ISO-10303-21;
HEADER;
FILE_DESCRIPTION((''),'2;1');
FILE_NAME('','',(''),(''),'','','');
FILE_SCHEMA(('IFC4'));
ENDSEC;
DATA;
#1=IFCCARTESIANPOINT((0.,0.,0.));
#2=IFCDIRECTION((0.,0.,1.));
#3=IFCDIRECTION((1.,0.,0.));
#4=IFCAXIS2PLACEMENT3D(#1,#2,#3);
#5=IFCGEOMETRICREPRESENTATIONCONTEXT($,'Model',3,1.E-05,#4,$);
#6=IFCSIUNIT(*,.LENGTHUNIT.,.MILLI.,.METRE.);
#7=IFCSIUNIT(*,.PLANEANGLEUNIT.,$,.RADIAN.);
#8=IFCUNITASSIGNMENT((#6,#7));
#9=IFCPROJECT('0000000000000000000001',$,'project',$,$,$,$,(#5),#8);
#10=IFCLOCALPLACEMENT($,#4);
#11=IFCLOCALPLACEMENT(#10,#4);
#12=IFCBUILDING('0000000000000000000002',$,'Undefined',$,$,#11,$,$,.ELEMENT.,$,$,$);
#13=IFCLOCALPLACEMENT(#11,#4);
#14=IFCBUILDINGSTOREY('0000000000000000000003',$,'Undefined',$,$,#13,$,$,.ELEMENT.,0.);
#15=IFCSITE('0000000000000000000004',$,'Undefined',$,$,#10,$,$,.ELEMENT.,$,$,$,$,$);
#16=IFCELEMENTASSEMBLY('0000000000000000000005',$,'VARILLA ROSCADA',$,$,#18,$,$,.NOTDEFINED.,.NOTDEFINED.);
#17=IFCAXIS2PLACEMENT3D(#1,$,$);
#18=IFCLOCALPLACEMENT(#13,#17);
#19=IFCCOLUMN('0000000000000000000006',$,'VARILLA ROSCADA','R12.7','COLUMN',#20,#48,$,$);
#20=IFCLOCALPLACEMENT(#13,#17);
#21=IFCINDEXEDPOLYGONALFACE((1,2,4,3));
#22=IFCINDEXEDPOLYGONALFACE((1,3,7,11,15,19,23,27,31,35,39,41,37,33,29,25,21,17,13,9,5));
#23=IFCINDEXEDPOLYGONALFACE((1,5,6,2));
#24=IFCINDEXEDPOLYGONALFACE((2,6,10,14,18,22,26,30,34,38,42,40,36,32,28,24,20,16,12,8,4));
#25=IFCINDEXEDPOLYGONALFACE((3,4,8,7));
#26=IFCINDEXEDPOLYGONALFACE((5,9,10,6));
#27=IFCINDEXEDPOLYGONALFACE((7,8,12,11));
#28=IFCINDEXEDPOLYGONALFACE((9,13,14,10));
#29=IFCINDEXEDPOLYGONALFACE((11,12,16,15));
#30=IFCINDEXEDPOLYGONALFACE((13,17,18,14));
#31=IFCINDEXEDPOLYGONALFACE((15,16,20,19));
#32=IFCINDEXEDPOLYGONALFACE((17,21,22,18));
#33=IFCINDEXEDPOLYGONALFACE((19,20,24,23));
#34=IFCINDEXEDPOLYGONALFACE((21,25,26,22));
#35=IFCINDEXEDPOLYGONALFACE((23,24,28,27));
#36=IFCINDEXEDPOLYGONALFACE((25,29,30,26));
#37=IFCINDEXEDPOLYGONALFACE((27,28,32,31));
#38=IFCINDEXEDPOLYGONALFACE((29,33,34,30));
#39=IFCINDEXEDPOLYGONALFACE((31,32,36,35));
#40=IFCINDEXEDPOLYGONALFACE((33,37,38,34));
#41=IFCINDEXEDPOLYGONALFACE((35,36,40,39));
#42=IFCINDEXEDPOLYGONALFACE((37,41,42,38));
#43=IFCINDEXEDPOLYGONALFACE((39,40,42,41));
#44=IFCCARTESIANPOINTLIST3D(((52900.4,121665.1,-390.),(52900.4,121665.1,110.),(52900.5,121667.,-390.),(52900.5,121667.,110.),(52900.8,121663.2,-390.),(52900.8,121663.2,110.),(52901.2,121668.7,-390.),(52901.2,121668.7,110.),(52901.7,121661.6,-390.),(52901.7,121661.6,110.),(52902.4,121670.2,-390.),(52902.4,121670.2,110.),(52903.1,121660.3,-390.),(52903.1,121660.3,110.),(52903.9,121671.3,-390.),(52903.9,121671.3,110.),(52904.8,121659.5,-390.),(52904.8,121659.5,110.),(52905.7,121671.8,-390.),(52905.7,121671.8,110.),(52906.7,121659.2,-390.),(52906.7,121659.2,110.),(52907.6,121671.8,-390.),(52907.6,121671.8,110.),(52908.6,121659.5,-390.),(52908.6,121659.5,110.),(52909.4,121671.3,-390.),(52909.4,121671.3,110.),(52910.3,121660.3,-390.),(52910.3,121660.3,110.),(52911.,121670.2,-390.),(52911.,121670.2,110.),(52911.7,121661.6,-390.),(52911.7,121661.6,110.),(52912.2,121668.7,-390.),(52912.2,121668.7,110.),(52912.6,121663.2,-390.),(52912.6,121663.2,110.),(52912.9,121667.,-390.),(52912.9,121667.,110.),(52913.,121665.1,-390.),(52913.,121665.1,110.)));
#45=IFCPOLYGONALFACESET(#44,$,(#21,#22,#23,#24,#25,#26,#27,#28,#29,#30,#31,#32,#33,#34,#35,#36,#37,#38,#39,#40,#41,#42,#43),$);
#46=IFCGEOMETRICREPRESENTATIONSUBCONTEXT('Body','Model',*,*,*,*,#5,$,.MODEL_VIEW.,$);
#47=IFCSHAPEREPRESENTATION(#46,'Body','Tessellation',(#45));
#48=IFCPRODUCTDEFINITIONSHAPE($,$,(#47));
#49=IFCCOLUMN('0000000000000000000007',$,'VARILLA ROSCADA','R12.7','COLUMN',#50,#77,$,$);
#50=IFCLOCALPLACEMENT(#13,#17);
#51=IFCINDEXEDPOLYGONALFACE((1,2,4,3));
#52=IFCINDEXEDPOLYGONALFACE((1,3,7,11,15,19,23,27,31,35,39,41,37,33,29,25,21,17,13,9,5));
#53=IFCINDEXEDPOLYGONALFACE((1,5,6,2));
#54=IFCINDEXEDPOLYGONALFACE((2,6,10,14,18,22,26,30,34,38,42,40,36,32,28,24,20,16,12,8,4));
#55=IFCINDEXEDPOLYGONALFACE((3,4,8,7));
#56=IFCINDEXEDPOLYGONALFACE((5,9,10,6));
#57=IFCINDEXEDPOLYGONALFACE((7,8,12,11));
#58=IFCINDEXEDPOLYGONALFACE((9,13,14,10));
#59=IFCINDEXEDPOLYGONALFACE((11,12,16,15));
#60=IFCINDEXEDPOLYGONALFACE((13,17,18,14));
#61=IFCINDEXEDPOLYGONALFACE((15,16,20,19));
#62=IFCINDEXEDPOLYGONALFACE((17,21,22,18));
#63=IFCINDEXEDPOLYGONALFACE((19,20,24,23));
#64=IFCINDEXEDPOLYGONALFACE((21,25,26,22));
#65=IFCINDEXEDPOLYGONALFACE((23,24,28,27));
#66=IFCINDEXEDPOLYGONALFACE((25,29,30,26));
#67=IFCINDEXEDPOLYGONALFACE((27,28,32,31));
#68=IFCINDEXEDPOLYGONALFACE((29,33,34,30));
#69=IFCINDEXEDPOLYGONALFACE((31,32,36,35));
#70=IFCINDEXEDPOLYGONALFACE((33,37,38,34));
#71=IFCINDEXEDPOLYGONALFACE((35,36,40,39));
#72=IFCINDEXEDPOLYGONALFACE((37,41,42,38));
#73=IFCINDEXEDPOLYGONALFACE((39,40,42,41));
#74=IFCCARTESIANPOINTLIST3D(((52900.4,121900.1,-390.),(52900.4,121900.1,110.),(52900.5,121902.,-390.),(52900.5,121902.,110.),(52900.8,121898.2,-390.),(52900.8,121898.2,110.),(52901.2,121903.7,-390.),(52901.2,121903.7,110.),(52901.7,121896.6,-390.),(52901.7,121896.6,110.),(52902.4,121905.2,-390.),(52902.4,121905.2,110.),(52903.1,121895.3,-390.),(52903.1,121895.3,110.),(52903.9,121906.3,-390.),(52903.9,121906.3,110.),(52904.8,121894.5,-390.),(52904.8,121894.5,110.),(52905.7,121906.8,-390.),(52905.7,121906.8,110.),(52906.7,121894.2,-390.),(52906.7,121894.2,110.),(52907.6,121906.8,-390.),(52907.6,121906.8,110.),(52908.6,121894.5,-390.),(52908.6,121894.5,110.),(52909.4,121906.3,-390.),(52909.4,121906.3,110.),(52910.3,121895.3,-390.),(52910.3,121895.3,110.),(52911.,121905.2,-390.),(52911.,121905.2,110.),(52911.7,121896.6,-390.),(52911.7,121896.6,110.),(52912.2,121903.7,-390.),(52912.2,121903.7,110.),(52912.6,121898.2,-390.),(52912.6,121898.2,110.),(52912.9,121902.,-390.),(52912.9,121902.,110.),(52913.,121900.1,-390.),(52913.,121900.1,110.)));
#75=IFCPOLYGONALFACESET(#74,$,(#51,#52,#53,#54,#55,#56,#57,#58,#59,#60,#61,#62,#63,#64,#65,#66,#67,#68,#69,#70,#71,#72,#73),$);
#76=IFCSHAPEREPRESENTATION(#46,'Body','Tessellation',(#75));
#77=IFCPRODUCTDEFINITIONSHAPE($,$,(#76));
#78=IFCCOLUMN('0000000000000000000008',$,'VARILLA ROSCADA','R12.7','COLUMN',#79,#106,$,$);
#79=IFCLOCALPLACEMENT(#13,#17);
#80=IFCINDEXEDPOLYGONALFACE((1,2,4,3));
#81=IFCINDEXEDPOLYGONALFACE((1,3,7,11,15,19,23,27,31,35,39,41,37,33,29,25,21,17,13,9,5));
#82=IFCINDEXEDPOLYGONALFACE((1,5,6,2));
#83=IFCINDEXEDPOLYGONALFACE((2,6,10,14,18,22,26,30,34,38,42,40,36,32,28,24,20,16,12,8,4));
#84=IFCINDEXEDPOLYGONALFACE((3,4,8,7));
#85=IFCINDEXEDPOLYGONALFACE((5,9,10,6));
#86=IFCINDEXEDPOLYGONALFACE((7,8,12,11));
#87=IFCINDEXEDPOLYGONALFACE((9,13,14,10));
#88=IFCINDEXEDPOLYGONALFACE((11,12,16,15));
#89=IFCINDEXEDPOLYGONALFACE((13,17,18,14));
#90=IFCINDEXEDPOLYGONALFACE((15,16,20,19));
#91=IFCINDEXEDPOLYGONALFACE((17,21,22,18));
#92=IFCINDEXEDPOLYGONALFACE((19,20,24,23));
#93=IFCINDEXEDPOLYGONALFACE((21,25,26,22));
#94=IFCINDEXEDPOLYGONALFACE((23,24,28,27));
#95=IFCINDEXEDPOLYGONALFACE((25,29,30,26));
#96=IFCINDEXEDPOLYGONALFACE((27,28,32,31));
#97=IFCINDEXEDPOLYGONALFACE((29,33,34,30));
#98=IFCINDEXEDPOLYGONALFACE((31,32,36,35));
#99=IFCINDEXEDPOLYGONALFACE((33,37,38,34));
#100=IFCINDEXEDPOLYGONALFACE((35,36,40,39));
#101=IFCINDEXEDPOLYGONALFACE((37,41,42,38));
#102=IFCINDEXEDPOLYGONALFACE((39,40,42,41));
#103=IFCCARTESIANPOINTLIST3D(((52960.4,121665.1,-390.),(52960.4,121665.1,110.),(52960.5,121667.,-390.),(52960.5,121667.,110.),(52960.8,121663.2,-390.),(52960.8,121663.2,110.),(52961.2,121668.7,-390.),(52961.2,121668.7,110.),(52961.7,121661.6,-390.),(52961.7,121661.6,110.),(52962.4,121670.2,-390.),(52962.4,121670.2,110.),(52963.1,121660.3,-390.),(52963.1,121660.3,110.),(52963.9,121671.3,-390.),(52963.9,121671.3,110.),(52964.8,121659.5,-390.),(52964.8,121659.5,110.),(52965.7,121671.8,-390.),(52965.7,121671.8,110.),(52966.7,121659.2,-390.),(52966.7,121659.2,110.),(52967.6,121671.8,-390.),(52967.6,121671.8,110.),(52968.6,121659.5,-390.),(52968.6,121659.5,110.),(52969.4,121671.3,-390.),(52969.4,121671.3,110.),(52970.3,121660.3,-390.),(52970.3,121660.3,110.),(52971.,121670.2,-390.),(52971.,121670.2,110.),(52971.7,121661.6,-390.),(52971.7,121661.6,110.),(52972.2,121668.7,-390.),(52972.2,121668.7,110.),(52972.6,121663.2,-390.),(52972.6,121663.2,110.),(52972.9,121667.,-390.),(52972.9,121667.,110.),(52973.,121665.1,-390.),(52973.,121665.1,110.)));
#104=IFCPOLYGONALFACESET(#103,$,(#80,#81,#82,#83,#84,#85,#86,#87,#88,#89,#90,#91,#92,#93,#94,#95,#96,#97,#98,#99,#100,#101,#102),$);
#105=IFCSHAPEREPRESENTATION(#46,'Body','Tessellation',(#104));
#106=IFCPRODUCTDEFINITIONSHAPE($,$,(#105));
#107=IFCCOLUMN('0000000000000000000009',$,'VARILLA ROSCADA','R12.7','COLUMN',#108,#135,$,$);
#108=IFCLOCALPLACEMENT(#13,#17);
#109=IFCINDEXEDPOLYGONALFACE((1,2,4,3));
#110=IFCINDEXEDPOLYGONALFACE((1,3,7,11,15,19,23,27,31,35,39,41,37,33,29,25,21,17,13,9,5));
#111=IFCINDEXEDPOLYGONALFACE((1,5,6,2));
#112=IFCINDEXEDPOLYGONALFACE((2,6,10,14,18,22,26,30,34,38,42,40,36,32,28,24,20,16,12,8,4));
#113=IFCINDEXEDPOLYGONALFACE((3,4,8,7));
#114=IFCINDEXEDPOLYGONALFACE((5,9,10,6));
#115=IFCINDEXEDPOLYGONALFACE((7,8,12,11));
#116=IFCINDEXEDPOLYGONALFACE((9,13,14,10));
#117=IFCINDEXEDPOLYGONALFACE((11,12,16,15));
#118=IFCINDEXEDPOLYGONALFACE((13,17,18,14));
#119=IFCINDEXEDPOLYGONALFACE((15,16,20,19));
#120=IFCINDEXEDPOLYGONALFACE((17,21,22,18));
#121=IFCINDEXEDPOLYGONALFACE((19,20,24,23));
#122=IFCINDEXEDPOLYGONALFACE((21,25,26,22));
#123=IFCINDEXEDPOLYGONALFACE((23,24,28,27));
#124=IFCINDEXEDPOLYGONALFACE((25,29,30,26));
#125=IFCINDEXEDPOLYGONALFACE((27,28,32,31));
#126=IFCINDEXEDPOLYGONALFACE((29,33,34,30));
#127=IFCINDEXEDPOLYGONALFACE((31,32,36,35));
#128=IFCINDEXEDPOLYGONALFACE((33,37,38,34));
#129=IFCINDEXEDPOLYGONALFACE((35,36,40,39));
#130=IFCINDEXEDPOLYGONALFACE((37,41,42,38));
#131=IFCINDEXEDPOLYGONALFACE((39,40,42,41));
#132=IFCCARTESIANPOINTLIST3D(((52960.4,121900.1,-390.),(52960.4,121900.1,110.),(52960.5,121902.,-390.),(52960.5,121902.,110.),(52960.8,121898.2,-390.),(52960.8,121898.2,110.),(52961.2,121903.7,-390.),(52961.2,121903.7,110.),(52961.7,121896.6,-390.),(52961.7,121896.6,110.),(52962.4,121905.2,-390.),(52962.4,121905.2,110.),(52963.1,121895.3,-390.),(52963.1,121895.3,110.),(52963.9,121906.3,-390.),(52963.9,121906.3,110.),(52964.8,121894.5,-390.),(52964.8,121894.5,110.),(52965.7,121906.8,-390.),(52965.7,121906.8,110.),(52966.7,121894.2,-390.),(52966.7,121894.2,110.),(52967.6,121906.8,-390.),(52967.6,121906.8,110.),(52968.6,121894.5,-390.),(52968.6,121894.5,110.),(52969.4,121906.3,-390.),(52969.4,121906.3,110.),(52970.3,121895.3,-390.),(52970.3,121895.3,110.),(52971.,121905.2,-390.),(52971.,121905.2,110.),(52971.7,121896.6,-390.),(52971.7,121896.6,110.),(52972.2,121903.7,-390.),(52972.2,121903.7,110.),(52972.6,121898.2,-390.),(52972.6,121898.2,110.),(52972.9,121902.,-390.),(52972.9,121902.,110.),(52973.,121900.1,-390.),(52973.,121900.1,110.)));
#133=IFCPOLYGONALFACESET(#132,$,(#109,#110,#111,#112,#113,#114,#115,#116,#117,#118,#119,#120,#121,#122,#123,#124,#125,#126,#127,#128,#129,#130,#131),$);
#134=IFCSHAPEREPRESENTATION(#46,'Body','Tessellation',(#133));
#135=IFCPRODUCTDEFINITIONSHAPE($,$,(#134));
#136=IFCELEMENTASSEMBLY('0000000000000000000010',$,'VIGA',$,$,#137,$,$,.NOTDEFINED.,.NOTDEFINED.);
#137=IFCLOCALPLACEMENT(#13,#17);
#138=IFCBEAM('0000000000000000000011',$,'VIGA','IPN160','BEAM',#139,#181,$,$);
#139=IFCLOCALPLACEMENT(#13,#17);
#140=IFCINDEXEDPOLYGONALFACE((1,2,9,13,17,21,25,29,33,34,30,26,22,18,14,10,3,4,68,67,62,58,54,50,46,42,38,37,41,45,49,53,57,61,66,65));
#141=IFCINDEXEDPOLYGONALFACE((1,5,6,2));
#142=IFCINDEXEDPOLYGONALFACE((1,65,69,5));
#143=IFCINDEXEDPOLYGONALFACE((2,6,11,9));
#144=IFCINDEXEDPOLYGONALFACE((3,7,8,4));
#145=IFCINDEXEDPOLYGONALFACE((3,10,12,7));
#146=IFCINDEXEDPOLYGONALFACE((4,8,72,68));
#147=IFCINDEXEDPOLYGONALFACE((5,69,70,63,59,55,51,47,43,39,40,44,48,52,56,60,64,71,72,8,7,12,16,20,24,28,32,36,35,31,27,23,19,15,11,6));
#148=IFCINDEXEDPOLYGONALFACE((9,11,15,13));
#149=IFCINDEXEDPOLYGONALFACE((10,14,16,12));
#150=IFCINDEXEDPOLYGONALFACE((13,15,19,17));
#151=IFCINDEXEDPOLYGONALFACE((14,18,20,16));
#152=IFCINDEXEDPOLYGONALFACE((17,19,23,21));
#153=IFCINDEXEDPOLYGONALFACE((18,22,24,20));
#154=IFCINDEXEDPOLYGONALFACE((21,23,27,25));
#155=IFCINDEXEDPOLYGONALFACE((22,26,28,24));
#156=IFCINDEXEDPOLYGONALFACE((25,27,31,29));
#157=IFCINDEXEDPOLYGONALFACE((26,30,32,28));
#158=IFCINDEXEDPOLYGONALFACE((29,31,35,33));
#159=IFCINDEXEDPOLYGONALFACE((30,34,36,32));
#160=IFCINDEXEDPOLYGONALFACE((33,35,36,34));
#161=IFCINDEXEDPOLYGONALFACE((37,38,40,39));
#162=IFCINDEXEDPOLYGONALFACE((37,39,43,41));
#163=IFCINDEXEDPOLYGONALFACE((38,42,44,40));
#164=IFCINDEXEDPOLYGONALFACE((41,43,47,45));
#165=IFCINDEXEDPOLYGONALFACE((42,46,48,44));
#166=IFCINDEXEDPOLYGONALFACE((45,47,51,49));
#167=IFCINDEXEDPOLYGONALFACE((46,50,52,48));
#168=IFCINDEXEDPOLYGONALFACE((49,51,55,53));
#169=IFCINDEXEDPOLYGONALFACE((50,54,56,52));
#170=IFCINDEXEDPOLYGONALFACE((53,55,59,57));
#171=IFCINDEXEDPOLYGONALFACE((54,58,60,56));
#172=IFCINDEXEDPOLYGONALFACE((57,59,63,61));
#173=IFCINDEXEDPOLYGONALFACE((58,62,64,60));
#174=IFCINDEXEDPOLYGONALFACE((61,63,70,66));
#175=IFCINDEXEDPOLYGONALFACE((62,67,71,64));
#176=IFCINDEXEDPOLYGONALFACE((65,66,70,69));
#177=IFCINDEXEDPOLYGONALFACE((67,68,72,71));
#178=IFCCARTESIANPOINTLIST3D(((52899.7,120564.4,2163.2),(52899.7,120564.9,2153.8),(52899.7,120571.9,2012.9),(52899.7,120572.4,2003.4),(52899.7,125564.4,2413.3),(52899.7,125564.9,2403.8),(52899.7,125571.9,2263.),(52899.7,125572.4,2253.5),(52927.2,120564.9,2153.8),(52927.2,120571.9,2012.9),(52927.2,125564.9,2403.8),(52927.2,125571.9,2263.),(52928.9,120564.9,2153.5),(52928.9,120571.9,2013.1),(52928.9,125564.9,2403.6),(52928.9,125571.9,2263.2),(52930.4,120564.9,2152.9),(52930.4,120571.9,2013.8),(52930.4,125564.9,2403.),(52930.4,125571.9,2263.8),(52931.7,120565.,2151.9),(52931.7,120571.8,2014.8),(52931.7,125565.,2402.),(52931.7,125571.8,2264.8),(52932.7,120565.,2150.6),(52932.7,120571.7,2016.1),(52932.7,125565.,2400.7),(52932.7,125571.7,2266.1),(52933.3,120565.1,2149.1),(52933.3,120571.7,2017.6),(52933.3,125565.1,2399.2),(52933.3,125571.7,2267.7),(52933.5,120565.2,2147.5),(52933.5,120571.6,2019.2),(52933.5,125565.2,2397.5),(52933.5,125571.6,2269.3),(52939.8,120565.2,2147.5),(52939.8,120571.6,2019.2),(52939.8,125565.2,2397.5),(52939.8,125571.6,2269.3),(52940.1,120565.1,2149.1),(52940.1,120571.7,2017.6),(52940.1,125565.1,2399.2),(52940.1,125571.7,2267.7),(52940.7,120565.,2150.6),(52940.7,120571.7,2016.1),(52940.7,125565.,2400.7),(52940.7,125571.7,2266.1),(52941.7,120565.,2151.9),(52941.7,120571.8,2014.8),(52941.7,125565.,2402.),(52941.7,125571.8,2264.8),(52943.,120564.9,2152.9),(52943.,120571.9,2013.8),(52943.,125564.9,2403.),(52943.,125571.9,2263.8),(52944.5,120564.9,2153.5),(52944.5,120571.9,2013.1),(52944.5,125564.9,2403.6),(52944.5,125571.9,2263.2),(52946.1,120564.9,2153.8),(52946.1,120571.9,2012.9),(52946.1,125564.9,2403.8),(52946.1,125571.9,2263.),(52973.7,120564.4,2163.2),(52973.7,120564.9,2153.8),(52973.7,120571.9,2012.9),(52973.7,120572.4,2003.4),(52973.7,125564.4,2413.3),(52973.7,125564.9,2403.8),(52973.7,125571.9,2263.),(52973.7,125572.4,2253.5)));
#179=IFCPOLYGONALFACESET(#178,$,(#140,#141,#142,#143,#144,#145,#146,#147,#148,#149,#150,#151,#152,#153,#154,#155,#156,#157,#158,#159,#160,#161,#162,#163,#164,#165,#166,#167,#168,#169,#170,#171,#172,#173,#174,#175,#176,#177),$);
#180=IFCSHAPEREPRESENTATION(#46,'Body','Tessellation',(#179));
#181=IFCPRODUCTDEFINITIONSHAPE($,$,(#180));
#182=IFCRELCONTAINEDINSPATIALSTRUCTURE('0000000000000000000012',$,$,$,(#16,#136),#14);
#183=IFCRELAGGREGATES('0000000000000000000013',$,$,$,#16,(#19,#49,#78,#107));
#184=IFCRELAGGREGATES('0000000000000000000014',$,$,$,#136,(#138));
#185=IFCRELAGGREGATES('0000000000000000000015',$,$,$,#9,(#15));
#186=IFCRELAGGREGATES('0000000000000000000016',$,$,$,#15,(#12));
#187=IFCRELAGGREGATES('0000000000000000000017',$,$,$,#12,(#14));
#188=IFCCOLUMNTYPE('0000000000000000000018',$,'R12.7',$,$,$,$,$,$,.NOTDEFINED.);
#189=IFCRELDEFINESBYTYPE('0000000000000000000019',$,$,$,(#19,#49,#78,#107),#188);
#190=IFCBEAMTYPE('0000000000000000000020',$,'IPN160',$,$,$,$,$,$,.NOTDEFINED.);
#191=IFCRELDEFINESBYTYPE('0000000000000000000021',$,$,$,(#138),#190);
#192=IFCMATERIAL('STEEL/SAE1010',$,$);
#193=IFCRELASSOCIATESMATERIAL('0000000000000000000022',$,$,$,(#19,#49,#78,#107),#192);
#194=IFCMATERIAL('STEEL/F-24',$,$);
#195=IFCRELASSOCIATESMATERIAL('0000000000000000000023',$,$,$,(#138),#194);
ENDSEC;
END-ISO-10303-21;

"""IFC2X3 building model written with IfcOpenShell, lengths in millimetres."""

from ifc_helpers import new_model, si_unit, frame, origin_with_axes, origin_2d_with_axis, place, context, subcontext, project, spatial, circle, i_section, extrude, material, type_object, element, aggregate, save


model = new_model("IFC2X3")

# Units and contexts
model_context = context("Model", 3, precision=1e-05, world=origin_with_axes())
body_context = subcontext(model_context, "Body", "Model", "MODEL_VIEW")
ifc_project = project(units=[si_unit("LENGTHUNIT", "METRE", prefix="MILLI"), si_unit("PLANEANGLEUNIT", "RADIAN")], contexts=[model_context])

# Site, building, storey
site_placement = place(None, origin_with_axes())
site = spatial("IfcSite", under=ifc_project, at=site_placement, Name="Undefined", CompositionType="ELEMENT")
building_placement = place(site_placement, origin_with_axes())
building = spatial("IfcBuilding", under=site, at=building_placement, Name="Undefined", CompositionType="ELEMENT")
storey_placement = place(building_placement, origin_with_axes())
storey = spatial("IfcBuildingStorey", under=building, at=storey_placement, Name="Undefined", CompositionType="ELEMENT", Elevation=0.0)

# Element assembly, columns
assembly_1_placement = place(storey_placement, origin_with_axes())
assembly_1 = element("IfcElementAssembly", 1, at=assembly_1_placement, inside=storey, Name="VARILLA ROSCADA", AssemblyPlace="NOTDEFINED", PredefinedType="NOTDEFINED")
ifc_material_1 = material(Name="STEEL/SAE1010")
column_type = type_object("IfcColumnType", Name="R12.7", PredefinedType="NOTDEFINED")
column_1_placement = place(assembly_1_placement, frame((52906.7, 121665.6, -390.0), z_axis=(0.0, 0.0, 1.0), x_axis=(-1.0, 0.0, 0.0)))
column_1 = element("IfcColumn", 2, at=column_1_placement, type_object=column_type, material=ifc_material_1, Name="VARILLA ROSCADA", Description="R12.7", ObjectType="COLUMN", context=body_context, shape_type="SweptSolid", body=[
    extrude(circle(Radius=6.3, at=origin_2d_with_axis()), frame((0.0, 0.0, 500.0), z_axis=(0.0, 0.0, -1.0), x_axis=(0.0, 1.0, 0.0)), (0.0, 0.0, 1.0), 500.0),
])
column_2_placement = place(assembly_1_placement, frame((52906.7, 121900.6, -390.0), z_axis=(0.0, 0.0, 1.0), x_axis=(-1.0, 0.0, 0.0)))
column_2 = element("IfcColumn", 3, at=column_2_placement, type_object=column_type, material=ifc_material_1, Name="VARILLA ROSCADA", Description="R12.7", ObjectType="COLUMN", context=body_context, shape_type="SweptSolid", body=[
    extrude(circle(Radius=6.3, at=origin_2d_with_axis()), frame((0.0, 0.0, 500.0), z_axis=(0.0, 0.0, -1.0), x_axis=(0.0, 1.0, 0.0)), (0.0, 0.0, 1.0), 500.0),
])
column_3_placement = place(assembly_1_placement, frame((52966.7, 121665.6, -390.0), z_axis=(0.0, 0.0, 1.0), x_axis=(-1.0, 0.0, 0.0)))
column_3 = element("IfcColumn", 4, at=column_3_placement, type_object=column_type, material=ifc_material_1, Name="VARILLA ROSCADA", Description="R12.7", ObjectType="COLUMN", context=body_context, shape_type="SweptSolid", body=[
    extrude(circle(Radius=6.3, at=origin_2d_with_axis()), frame((0.0, 0.0, 500.0), z_axis=(0.0, 0.0, -1.0), x_axis=(0.0, 1.0, 0.0)), (0.0, 0.0, 1.0), 500.0),
])
column_4_placement = place(assembly_1_placement, frame((52966.7, 121900.6, -390.0), z_axis=(0.0, 0.0, 1.0), x_axis=(-1.0, 0.0, 0.0)))
column_4 = element("IfcColumn", 5, at=column_4_placement, type_object=column_type, material=ifc_material_1, Name="VARILLA ROSCADA", Description="R12.7", ObjectType="COLUMN", context=body_context, shape_type="SweptSolid", body=[
    extrude(circle(Radius=6.3, at=origin_2d_with_axis()), frame((0.0, 0.0, 500.0), z_axis=(0.0, 0.0, -1.0), x_axis=(0.0, 1.0, 0.0)), (0.0, 0.0, 1.0), 500.0),
])

# Element assembly, beam
assembly_2_placement = place(storey_placement, origin_with_axes())
assembly_2 = element("IfcElementAssembly", 6, at=assembly_2_placement, inside=storey, Name="VIGA", AssemblyPlace="NOTDEFINED", PredefinedType="NOTDEFINED")
ifc_material_2 = material(Name="STEEL/F-24")
beam_type_1 = type_object("IfcBeamType", Name="IPN160", PredefinedType="NOTDEFINED")
beam_1_placement = place(assembly_2_placement, frame((52936.7, 120568.4, 2083.3), z_axis=(0.0, -0.04995, 0.998752), x_axis=(0.0, 0.998752, 0.04995)))
beam_1 = element("IfcBeam", 7, at=beam_1_placement, type_object=beam_type_1, material=ifc_material_2, Name="VIGA", Description="IPN160", ObjectType="BEAM", context=body_context, shape_type="SweptSolid", body=[
    extrude(i_section(OverallWidth=74.0, OverallDepth=160.0, WebThickness=6.3, FlangeThickness=9.5, FilletRadius=6.3, at=origin_2d_with_axis()), frame((5006.2, 0.0, 0.0), z_axis=(-1.0, 0.0, 0.0), x_axis=(0.0, -1.0, 0.0)), (0.0, 0.0, 1.0), 5006.2),
])

aggregate(assembly_1, [column_1, column_2, column_3, column_4])
aggregate(assembly_2, [beam_1])

save(model, "model.ifc")
